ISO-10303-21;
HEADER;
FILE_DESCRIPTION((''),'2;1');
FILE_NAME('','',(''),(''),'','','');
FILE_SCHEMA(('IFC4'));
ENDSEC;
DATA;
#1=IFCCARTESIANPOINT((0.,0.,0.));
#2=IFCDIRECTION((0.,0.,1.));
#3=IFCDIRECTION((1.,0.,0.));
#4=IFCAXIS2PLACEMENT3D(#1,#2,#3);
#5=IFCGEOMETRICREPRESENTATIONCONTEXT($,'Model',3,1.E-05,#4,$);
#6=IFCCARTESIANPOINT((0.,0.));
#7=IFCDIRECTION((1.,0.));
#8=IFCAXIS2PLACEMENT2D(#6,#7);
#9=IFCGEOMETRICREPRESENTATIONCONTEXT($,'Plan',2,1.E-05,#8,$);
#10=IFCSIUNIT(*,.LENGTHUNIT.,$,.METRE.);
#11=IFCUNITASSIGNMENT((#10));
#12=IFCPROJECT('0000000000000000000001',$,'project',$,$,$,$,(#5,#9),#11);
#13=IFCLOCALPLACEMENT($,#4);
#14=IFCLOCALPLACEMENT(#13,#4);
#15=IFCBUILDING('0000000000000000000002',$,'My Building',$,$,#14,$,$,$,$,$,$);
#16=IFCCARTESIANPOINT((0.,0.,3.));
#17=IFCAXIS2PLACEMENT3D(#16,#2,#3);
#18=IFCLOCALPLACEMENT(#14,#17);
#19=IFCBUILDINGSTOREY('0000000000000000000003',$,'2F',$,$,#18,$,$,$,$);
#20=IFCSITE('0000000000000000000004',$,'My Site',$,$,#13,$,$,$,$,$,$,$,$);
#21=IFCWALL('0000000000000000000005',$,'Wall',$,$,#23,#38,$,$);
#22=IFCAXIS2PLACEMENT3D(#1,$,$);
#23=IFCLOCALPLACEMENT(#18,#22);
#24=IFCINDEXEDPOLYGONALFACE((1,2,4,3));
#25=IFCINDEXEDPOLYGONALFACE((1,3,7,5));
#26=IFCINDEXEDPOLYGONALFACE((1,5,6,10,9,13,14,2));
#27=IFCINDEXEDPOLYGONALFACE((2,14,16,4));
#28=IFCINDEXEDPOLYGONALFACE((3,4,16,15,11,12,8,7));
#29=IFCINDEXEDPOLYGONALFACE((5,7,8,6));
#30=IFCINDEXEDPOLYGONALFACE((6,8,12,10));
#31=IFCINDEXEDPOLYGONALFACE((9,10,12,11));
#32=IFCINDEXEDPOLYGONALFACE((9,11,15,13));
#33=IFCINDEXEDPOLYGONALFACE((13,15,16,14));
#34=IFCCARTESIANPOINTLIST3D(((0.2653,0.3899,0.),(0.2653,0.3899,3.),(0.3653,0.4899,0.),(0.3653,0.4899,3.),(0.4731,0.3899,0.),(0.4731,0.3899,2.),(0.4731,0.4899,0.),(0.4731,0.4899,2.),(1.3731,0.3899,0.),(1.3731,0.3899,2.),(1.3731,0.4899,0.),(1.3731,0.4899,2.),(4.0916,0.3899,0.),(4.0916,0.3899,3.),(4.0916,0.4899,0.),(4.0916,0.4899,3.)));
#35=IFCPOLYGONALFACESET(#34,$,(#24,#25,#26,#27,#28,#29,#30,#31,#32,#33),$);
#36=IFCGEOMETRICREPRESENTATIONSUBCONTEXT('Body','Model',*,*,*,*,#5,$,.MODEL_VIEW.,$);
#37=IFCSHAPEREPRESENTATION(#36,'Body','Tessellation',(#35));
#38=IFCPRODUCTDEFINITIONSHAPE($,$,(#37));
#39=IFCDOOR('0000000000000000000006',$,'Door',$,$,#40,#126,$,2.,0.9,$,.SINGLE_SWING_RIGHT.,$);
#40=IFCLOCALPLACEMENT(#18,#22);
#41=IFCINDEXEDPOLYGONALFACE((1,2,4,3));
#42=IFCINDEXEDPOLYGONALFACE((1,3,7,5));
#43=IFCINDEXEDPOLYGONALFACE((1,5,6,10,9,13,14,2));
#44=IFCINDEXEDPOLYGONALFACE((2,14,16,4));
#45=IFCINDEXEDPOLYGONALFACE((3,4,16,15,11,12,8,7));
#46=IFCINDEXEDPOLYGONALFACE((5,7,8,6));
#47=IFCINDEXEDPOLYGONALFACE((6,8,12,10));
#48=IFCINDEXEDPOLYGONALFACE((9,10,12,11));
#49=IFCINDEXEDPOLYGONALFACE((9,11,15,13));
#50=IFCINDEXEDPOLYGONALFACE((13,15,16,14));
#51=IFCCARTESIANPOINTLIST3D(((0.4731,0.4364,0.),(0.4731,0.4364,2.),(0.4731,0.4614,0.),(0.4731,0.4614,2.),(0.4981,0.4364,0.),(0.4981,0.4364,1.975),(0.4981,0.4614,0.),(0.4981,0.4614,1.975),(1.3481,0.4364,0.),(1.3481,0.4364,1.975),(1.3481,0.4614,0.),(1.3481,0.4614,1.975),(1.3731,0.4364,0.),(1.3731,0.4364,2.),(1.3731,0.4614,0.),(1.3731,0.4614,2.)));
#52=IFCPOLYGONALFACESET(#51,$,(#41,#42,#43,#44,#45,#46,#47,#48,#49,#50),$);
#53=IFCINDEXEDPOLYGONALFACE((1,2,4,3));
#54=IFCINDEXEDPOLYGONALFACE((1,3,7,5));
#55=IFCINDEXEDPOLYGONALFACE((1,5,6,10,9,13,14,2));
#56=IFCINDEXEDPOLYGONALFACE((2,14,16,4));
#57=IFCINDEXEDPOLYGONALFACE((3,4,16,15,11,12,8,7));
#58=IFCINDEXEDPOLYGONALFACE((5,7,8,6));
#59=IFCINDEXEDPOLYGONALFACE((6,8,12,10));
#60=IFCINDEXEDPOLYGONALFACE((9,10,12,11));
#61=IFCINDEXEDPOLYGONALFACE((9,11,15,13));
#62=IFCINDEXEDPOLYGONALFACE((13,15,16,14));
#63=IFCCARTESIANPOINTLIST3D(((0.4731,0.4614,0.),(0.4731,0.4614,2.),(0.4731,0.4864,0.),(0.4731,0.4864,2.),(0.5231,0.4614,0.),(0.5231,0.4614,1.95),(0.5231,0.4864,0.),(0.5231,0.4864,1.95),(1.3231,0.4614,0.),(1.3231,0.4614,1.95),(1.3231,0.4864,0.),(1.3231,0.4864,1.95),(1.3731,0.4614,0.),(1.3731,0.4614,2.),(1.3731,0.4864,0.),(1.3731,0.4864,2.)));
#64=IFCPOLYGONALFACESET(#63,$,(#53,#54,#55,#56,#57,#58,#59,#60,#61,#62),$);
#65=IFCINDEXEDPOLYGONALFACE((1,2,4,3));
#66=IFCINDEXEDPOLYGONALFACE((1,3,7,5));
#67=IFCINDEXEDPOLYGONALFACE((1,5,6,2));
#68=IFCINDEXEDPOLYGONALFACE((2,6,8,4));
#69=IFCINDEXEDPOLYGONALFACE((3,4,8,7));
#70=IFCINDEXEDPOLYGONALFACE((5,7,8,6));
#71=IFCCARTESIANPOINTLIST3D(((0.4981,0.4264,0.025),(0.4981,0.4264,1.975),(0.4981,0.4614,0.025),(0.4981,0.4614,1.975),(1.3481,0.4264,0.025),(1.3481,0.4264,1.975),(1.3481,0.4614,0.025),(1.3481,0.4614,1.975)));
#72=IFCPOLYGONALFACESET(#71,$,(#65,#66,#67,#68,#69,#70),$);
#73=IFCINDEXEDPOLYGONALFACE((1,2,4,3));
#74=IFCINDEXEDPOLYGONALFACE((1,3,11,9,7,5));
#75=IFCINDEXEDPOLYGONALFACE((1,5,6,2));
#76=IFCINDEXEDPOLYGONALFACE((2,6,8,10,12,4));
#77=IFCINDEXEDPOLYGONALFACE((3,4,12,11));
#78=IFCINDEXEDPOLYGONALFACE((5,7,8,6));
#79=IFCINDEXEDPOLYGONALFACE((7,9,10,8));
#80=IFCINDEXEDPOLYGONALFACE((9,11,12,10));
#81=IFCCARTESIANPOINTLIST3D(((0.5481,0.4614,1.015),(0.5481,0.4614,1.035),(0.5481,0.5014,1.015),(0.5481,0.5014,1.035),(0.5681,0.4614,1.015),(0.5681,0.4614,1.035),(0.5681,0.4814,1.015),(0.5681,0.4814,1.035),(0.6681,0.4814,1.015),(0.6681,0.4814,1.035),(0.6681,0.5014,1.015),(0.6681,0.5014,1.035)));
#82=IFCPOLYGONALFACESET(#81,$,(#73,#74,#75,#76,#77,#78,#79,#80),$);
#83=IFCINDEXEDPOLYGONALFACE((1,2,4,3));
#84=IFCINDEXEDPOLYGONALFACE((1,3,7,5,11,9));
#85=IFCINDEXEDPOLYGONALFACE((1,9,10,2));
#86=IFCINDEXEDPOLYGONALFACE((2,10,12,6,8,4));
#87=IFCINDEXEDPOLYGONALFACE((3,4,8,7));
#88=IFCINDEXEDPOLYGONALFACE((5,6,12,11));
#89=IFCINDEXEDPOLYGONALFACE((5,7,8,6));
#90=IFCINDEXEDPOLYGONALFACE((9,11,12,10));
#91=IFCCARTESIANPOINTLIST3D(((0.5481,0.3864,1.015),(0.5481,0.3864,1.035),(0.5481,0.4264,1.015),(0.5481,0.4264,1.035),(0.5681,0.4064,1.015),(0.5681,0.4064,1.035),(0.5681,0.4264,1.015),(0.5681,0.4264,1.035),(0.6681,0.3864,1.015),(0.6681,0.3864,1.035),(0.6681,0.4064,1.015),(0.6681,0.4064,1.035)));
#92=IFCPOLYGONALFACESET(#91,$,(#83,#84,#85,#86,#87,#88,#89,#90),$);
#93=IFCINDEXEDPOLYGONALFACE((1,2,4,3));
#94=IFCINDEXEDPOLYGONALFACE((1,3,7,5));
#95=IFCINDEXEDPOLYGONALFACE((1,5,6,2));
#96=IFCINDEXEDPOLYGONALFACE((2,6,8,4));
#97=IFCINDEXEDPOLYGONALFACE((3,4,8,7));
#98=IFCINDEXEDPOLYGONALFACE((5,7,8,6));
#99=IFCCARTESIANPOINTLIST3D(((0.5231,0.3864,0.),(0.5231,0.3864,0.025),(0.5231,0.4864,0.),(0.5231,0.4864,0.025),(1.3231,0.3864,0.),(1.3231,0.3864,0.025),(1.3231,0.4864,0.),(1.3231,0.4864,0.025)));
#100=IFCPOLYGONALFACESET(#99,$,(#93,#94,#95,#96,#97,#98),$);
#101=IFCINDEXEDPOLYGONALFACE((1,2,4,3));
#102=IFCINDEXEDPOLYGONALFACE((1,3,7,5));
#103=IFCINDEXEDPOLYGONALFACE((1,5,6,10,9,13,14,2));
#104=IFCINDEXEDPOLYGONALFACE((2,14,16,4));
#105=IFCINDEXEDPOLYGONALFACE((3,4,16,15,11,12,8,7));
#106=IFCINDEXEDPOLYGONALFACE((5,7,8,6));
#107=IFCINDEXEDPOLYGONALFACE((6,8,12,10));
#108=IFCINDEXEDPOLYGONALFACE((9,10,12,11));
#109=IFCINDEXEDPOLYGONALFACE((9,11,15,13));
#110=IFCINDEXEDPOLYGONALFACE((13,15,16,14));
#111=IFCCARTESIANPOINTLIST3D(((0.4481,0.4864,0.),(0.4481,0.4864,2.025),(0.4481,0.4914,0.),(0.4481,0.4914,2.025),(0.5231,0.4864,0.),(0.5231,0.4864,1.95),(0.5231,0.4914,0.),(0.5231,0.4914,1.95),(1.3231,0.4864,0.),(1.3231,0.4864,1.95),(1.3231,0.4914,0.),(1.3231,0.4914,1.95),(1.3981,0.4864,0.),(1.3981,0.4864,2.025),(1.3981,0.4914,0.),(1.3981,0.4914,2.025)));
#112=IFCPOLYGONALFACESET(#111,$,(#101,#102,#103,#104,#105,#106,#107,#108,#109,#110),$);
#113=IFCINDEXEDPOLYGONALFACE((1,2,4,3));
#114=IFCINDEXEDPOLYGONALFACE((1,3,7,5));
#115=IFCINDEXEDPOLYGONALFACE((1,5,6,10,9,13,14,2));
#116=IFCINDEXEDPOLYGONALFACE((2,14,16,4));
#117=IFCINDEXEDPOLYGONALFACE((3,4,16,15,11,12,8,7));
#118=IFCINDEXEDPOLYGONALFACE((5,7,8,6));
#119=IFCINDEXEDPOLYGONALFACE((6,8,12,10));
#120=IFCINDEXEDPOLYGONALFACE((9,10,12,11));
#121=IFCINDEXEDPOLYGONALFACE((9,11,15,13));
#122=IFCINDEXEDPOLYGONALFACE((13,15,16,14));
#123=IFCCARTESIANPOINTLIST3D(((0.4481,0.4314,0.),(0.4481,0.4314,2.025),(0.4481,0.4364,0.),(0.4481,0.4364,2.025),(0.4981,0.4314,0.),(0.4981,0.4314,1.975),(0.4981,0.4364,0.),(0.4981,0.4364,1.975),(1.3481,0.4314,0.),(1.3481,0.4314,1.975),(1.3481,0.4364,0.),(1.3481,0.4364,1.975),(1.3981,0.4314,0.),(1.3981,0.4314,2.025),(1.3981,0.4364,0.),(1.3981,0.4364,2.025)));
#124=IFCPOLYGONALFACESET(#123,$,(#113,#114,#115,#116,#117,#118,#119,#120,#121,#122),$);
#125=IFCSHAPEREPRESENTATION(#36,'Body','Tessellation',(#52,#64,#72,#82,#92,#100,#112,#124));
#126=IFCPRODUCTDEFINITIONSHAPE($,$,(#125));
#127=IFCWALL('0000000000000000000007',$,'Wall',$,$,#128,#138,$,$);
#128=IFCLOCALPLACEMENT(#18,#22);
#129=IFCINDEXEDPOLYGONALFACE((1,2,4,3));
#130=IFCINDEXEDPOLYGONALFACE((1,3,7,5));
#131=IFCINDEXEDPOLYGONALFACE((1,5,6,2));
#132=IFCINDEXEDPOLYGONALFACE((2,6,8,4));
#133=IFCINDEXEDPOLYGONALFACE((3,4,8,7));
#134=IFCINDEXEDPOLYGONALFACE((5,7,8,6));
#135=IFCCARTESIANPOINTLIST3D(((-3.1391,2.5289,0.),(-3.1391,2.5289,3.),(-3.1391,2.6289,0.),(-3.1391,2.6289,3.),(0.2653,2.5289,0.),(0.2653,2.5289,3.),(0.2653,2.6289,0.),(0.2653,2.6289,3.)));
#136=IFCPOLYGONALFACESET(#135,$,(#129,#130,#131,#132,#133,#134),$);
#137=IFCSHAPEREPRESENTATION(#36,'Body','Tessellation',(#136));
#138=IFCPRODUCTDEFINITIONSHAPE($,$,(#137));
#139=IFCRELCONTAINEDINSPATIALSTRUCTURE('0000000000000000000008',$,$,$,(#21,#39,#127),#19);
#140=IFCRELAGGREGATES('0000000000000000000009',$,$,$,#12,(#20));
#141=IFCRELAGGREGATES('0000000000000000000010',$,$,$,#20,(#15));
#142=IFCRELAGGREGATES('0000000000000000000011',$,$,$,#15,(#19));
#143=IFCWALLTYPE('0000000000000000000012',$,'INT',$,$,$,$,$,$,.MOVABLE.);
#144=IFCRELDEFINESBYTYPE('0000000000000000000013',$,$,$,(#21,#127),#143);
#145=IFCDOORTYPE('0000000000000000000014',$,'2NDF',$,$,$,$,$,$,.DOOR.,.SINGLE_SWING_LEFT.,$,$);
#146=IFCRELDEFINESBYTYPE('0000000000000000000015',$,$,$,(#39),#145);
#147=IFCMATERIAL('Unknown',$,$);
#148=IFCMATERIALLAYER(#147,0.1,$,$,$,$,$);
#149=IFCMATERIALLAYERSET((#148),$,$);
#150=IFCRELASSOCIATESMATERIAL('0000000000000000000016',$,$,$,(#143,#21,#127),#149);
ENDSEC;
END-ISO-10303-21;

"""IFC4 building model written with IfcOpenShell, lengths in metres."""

from ifc_helpers import new_model, entity, si_unit, frame, origin_with_axes, origin_2d_with_axis, place, context, subcontext, project, spatial, line, indexed_curve, outline, extrude, shape, source, transform, mapped, material, layer, layer_set, layer_usage, type_object, type_shapes, element, fill, save


model = new_model("IFC4")

# Units and contexts
model_context = context("Model", 3, precision=1e-05, world=origin_with_axes())
plan_context = context("Plan", 2, precision=1e-05, world=origin_2d_with_axis())
body_context_1 = subcontext(model_context, "Body", "Model", "MODEL_VIEW")
body_context_2 = subcontext(plan_context, "Body", "Plan", "PLAN_VIEW")
ifc_project = project(units=[si_unit("LENGTHUNIT", "METRE")], contexts=[model_context, plan_context])

# Site, building, storey
site_placement = place(None, origin_with_axes())
site = spatial("IfcSite", under=ifc_project, at=site_placement, Name="My Site")
building_placement = place(site_placement, origin_with_axes())
building = spatial("IfcBuilding", under=site, at=building_placement, Name="My Building")
storey_placement = place(building_placement, frame((0.0, 0.0, 3.0), z_axis=(0.0, 0.0, 1.0), x_axis=(1.0, 0.0, 0.0)))
storey = spatial("IfcBuildingStorey", under=building, at=storey_placement, Name="2F")

# Shared definitions
ifc_material = material(Name="Unknown")

# Shared definitions
ifc_layer_1 = layer(ifc_material, 0.1)
ifc_layer_set_1 = layer_set([ifc_layer_1])
wall_type_1 = type_object("IfcWallType", Name="INT", PredefinedType="MOVABLE", material=ifc_layer_set_1)
door_type_1 = type_object("IfcDoorType", Name="2NDF", OperationType="SINGLE_SWING_LEFT", PredefinedType="DOOR")
shared_shape_1 = source(origin_with_axes(), body_context_1, "Body", "SweptSolid", [
    extrude(outline(indexed_curve([(0.0, 0.0), (0.0, 2.0), (0.9, 2.0), (0.9, 0.0), (0.875, 0.0), (0.875, 1.975), (0.025, 1.975), (0.025, 0.0)], segments=[line(1, 2, 3, 4, 5, 6, 7, 8, 1)])), frame((0.0, 0.025, 0.0), z_axis=(0.0, -1.0, 0.0), x_axis=(1.0, 0.0, 0.0)), (0.0, 0.0, -1.0), 0.025),
    extrude(outline(indexed_curve([(0.0, 0.0), (0.0, 2.0), (0.9, 2.0), (0.9, 0.0), (0.85, 0.0), (0.85, 1.95), (0.05, 1.95), (0.05, 0.0)], segments=[line(1, 2, 3, 4, 5, 6, 7, 8, 1)])), frame((0.0, 0.0, 0.0), z_axis=(0.0, -1.0, 0.0), x_axis=(1.0, 0.0, 0.0)), (0.0, 0.0, -1.0), 0.025),
    extrude(outline(indexed_curve([(0.0, 0.0), (0.85, 0.0), (0.85, 0.035), (0.0, 0.035)], segments=[line(1, 2, 3, 4, 1)])), frame((0.025, 0.025, 0.025), z_axis=(0.0, 0.0, 1.0), x_axis=(1.0, 0.0, 0.0)), (0.0, 0.0, 1.0), 1.95),
    extrude(outline(indexed_curve([(0.0, 0.0), (0.0, -0.04), (-0.12, -0.04), (-0.12, -0.02), (-0.02, -0.02), (-0.02, 0.0)], segments=[line(1, 2, 3, 4, 5, 6, 1)])), frame((0.825, 0.025, 1.015), z_axis=(0.0, 0.0, 1.0), x_axis=(1.0, 0.0, 0.0)), (0.0, 0.0, 1.0), 0.02),
    extrude(outline(indexed_curve([(0.0, 0.0), (0.0, 0.04), (-0.12, 0.04), (-0.12, 0.02), (-0.02, 0.02), (-0.02, 0.0)], segments=[line(1, 2, 3, 4, 5, 6, 1)])), frame((0.825, 0.06, 1.015), z_axis=(0.0, 0.0, 1.0), x_axis=(1.0, 0.0, 0.0)), (0.0, 0.0, 1.0), 0.02),
    extrude(outline(indexed_curve([(0.0, 0.0), (0.8, 0.0), (0.8, 0.1), (0.0, 0.1)], segments=[line(1, 2, 3, 4, 1)])), frame((0.05, 0.0, 0.0), z_axis=(0.0, 0.0, 1.0), x_axis=(1.0, 0.0, 0.0)), (0.0, 0.0, 1.0), 0.025),
    extrude(outline(indexed_curve([(0.0, 0.0), (0.0, 2.025), (0.95, 2.025), (0.95, 0.0), (0.875, 0.0), (0.875, 1.95), (0.075, 1.95), (0.075, 0.0)], segments=[line(1, 2, 3, 4, 5, 6, 7, 8, 1)])), frame((-0.025, -0.005, 0.0), z_axis=(0.0, -1.0, 0.0), x_axis=(1.0, 0.0, 0.0)), (0.0, 0.0, -1.0), 0.005),
    extrude(outline(indexed_curve([(0.0, 0.0), (0.0, 2.025), (0.95, 2.025), (0.95, 0.0), (0.9, 0.0), (0.9, 1.975), (0.05, 1.975), (0.05, 0.0)], segments=[line(1, 2, 3, 4, 5, 6, 7, 8, 1)])), frame((-0.025, 0.05, 0.0), z_axis=(0.0, -1.0, 0.0), x_axis=(1.0, 0.0, 0.0)), (0.0, 0.0, -1.0), 0.005),
])
shared_shape_2 = source(origin_with_axes(), body_context_2, "Body", "Curve2D", [
    entity("IfcIndexedPolyCurve", entity("IfcCartesianPointList2D", [[0.0, 0.0], [0.0, 0.05], [0.025, 0.05], [0.025, 0.025], [0.05, 0.025], [0.05, 0.0]]), [entity("IfcLineIndex", [1, 2, 3, 4, 5, 6, 1])]),
    entity("IfcIndexedPolyCurve", entity("IfcCartesianPointList2D", [[0.9, 0.0], [0.9, 0.05], [0.875, 0.05], [0.875, 0.025], [0.85, 0.025], [0.85, 0.0]]), [entity("IfcLineIndex", [1, 2, 3, 4, 5, 6, 1])]),
    entity("IfcTrimmedCurve", entity("IfcEllipse", entity("IfcAxis2Placement2D", entity("IfcCartesianPoint", [0.06, 0.05]), entity("IfcDirection", [1.0, 0.0])), 0.815, 0.85), [entity("IfcCartesianPoint", [0.875, 0.05])], [entity("IfcCartesianPoint", [0.06, 0.9])], True, "CARTESIAN"),
    entity("IfcIndexedPolyCurve", entity("IfcCartesianPointList2D", [[0.025, 0.05], [0.06, 0.05], [0.06, 0.9], [0.025, 0.9]]), [entity("IfcLineIndex", [1, 2, 3, 4, 1])]),
])
type_shapes(door_type_1, [shared_shape_1, shared_shape_2])

# Wall, opening, door
ifc_layer_usage_1 = layer_usage(ifc_layer_set_1, "AXIS2", "POSITIVE", -0.1)
wall_1_placement = place(storey_placement, frame((0.3653, 0.4899, 0.0), z_axis=(0.0, 0.0, 1.0), x_axis=(1.0, 0.0, 0.0)))
wall_1 = element("IfcWall", 1, at=wall_1_placement, inside=storey, type_object=wall_type_1, material=ifc_layer_usage_1, Name="Wall", context=body_context_1, shape_type="SweptSolid", body=[
    extrude(outline(indexed_curve([(-0.1, -0.1), (0.0, 0.0), (3.7262, 0.0), (3.7262, -0.1)], segments=[line(1, 2, 3, 4, 1)])), origin_with_axes(), (0.0, 0.0, 1.0), 3.0),
])
placement_1 = place(storey_placement, frame((1.3731, 0.4864, 0.0), z_axis=(0.0, 0.0, 1.0), x_axis=(-1.0, 0.0, 0.0)))
opening_1 = element("IfcOpeningElement", 2, at=placement_1, cuts=wall_1, PredefinedType="OPENING", context=body_context_1, shape_type="SweptSolid", body=[
    extrude(outline(indexed_curve([(0.0, 0.0), (0.9, 0.0), (0.9, 2.0), (0.0, 2.0)], segments=[line(1, 2, 3, 4, 1)])), frame((0.0, -0.6, 0.0), z_axis=(0.0, -1.0, 0.0), x_axis=(1.0, 0.0, 0.0)), (0.0, 0.0, -1.0), 1.2),
])
door_1 = element("IfcDoor", 3, at=placement_1, inside=storey, type_object=door_type_1, Name="Door", OperationType="SINGLE_SWING_RIGHT", OverallHeight=2.0, OverallWidth=0.9, shapes=[
    shape(body_context_1, "Body", "MappedRepresentation", [mapped(shared_shape_1, transform((0.0, 0.0, 0.0), x_axis=(1.0, 0.0, 0.0), y_axis=(0.0, 1.0, 0.0), z_axis=(0.0, 0.0, 1.0), scale=1.0))]),
    shape(body_context_2, "Body", "MappedRepresentation", [mapped(shared_shape_2, transform((0.0, 0.0, 0.0), x_axis=(1.0, 0.0, 0.0), y_axis=(0.0, 1.0, 0.0), z_axis=(0.0, 0.0, 1.0), scale=1.0))]),
])
fill(opening_1, door_1)

# Wall
ifc_layer_usage_2 = layer_usage(ifc_layer_set_1, "AXIS2", "POSITIVE", -0.1)
wall_2_placement = place(storey_placement, frame((-3.1391, 2.6289, 0.0), z_axis=(0.0, 0.0, 1.0), x_axis=(1.0, 0.0, 0.0)))
element("IfcWall", 4, at=wall_2_placement, inside=storey, type_object=wall_type_1, material=ifc_layer_usage_2, Name="Wall", context=body_context_1, shape_type="SweptSolid", body=[
    extrude(outline(indexed_curve([(0.0, -0.1), (0.0, 0.0), (3.4045, 0.0), (3.4045, -0.1)], segments=[line(1, 2, 3, 4, 1)])), origin_with_axes(), (0.0, 0.0, 1.0), 3.0),
])

save(model, "model.ifc")
